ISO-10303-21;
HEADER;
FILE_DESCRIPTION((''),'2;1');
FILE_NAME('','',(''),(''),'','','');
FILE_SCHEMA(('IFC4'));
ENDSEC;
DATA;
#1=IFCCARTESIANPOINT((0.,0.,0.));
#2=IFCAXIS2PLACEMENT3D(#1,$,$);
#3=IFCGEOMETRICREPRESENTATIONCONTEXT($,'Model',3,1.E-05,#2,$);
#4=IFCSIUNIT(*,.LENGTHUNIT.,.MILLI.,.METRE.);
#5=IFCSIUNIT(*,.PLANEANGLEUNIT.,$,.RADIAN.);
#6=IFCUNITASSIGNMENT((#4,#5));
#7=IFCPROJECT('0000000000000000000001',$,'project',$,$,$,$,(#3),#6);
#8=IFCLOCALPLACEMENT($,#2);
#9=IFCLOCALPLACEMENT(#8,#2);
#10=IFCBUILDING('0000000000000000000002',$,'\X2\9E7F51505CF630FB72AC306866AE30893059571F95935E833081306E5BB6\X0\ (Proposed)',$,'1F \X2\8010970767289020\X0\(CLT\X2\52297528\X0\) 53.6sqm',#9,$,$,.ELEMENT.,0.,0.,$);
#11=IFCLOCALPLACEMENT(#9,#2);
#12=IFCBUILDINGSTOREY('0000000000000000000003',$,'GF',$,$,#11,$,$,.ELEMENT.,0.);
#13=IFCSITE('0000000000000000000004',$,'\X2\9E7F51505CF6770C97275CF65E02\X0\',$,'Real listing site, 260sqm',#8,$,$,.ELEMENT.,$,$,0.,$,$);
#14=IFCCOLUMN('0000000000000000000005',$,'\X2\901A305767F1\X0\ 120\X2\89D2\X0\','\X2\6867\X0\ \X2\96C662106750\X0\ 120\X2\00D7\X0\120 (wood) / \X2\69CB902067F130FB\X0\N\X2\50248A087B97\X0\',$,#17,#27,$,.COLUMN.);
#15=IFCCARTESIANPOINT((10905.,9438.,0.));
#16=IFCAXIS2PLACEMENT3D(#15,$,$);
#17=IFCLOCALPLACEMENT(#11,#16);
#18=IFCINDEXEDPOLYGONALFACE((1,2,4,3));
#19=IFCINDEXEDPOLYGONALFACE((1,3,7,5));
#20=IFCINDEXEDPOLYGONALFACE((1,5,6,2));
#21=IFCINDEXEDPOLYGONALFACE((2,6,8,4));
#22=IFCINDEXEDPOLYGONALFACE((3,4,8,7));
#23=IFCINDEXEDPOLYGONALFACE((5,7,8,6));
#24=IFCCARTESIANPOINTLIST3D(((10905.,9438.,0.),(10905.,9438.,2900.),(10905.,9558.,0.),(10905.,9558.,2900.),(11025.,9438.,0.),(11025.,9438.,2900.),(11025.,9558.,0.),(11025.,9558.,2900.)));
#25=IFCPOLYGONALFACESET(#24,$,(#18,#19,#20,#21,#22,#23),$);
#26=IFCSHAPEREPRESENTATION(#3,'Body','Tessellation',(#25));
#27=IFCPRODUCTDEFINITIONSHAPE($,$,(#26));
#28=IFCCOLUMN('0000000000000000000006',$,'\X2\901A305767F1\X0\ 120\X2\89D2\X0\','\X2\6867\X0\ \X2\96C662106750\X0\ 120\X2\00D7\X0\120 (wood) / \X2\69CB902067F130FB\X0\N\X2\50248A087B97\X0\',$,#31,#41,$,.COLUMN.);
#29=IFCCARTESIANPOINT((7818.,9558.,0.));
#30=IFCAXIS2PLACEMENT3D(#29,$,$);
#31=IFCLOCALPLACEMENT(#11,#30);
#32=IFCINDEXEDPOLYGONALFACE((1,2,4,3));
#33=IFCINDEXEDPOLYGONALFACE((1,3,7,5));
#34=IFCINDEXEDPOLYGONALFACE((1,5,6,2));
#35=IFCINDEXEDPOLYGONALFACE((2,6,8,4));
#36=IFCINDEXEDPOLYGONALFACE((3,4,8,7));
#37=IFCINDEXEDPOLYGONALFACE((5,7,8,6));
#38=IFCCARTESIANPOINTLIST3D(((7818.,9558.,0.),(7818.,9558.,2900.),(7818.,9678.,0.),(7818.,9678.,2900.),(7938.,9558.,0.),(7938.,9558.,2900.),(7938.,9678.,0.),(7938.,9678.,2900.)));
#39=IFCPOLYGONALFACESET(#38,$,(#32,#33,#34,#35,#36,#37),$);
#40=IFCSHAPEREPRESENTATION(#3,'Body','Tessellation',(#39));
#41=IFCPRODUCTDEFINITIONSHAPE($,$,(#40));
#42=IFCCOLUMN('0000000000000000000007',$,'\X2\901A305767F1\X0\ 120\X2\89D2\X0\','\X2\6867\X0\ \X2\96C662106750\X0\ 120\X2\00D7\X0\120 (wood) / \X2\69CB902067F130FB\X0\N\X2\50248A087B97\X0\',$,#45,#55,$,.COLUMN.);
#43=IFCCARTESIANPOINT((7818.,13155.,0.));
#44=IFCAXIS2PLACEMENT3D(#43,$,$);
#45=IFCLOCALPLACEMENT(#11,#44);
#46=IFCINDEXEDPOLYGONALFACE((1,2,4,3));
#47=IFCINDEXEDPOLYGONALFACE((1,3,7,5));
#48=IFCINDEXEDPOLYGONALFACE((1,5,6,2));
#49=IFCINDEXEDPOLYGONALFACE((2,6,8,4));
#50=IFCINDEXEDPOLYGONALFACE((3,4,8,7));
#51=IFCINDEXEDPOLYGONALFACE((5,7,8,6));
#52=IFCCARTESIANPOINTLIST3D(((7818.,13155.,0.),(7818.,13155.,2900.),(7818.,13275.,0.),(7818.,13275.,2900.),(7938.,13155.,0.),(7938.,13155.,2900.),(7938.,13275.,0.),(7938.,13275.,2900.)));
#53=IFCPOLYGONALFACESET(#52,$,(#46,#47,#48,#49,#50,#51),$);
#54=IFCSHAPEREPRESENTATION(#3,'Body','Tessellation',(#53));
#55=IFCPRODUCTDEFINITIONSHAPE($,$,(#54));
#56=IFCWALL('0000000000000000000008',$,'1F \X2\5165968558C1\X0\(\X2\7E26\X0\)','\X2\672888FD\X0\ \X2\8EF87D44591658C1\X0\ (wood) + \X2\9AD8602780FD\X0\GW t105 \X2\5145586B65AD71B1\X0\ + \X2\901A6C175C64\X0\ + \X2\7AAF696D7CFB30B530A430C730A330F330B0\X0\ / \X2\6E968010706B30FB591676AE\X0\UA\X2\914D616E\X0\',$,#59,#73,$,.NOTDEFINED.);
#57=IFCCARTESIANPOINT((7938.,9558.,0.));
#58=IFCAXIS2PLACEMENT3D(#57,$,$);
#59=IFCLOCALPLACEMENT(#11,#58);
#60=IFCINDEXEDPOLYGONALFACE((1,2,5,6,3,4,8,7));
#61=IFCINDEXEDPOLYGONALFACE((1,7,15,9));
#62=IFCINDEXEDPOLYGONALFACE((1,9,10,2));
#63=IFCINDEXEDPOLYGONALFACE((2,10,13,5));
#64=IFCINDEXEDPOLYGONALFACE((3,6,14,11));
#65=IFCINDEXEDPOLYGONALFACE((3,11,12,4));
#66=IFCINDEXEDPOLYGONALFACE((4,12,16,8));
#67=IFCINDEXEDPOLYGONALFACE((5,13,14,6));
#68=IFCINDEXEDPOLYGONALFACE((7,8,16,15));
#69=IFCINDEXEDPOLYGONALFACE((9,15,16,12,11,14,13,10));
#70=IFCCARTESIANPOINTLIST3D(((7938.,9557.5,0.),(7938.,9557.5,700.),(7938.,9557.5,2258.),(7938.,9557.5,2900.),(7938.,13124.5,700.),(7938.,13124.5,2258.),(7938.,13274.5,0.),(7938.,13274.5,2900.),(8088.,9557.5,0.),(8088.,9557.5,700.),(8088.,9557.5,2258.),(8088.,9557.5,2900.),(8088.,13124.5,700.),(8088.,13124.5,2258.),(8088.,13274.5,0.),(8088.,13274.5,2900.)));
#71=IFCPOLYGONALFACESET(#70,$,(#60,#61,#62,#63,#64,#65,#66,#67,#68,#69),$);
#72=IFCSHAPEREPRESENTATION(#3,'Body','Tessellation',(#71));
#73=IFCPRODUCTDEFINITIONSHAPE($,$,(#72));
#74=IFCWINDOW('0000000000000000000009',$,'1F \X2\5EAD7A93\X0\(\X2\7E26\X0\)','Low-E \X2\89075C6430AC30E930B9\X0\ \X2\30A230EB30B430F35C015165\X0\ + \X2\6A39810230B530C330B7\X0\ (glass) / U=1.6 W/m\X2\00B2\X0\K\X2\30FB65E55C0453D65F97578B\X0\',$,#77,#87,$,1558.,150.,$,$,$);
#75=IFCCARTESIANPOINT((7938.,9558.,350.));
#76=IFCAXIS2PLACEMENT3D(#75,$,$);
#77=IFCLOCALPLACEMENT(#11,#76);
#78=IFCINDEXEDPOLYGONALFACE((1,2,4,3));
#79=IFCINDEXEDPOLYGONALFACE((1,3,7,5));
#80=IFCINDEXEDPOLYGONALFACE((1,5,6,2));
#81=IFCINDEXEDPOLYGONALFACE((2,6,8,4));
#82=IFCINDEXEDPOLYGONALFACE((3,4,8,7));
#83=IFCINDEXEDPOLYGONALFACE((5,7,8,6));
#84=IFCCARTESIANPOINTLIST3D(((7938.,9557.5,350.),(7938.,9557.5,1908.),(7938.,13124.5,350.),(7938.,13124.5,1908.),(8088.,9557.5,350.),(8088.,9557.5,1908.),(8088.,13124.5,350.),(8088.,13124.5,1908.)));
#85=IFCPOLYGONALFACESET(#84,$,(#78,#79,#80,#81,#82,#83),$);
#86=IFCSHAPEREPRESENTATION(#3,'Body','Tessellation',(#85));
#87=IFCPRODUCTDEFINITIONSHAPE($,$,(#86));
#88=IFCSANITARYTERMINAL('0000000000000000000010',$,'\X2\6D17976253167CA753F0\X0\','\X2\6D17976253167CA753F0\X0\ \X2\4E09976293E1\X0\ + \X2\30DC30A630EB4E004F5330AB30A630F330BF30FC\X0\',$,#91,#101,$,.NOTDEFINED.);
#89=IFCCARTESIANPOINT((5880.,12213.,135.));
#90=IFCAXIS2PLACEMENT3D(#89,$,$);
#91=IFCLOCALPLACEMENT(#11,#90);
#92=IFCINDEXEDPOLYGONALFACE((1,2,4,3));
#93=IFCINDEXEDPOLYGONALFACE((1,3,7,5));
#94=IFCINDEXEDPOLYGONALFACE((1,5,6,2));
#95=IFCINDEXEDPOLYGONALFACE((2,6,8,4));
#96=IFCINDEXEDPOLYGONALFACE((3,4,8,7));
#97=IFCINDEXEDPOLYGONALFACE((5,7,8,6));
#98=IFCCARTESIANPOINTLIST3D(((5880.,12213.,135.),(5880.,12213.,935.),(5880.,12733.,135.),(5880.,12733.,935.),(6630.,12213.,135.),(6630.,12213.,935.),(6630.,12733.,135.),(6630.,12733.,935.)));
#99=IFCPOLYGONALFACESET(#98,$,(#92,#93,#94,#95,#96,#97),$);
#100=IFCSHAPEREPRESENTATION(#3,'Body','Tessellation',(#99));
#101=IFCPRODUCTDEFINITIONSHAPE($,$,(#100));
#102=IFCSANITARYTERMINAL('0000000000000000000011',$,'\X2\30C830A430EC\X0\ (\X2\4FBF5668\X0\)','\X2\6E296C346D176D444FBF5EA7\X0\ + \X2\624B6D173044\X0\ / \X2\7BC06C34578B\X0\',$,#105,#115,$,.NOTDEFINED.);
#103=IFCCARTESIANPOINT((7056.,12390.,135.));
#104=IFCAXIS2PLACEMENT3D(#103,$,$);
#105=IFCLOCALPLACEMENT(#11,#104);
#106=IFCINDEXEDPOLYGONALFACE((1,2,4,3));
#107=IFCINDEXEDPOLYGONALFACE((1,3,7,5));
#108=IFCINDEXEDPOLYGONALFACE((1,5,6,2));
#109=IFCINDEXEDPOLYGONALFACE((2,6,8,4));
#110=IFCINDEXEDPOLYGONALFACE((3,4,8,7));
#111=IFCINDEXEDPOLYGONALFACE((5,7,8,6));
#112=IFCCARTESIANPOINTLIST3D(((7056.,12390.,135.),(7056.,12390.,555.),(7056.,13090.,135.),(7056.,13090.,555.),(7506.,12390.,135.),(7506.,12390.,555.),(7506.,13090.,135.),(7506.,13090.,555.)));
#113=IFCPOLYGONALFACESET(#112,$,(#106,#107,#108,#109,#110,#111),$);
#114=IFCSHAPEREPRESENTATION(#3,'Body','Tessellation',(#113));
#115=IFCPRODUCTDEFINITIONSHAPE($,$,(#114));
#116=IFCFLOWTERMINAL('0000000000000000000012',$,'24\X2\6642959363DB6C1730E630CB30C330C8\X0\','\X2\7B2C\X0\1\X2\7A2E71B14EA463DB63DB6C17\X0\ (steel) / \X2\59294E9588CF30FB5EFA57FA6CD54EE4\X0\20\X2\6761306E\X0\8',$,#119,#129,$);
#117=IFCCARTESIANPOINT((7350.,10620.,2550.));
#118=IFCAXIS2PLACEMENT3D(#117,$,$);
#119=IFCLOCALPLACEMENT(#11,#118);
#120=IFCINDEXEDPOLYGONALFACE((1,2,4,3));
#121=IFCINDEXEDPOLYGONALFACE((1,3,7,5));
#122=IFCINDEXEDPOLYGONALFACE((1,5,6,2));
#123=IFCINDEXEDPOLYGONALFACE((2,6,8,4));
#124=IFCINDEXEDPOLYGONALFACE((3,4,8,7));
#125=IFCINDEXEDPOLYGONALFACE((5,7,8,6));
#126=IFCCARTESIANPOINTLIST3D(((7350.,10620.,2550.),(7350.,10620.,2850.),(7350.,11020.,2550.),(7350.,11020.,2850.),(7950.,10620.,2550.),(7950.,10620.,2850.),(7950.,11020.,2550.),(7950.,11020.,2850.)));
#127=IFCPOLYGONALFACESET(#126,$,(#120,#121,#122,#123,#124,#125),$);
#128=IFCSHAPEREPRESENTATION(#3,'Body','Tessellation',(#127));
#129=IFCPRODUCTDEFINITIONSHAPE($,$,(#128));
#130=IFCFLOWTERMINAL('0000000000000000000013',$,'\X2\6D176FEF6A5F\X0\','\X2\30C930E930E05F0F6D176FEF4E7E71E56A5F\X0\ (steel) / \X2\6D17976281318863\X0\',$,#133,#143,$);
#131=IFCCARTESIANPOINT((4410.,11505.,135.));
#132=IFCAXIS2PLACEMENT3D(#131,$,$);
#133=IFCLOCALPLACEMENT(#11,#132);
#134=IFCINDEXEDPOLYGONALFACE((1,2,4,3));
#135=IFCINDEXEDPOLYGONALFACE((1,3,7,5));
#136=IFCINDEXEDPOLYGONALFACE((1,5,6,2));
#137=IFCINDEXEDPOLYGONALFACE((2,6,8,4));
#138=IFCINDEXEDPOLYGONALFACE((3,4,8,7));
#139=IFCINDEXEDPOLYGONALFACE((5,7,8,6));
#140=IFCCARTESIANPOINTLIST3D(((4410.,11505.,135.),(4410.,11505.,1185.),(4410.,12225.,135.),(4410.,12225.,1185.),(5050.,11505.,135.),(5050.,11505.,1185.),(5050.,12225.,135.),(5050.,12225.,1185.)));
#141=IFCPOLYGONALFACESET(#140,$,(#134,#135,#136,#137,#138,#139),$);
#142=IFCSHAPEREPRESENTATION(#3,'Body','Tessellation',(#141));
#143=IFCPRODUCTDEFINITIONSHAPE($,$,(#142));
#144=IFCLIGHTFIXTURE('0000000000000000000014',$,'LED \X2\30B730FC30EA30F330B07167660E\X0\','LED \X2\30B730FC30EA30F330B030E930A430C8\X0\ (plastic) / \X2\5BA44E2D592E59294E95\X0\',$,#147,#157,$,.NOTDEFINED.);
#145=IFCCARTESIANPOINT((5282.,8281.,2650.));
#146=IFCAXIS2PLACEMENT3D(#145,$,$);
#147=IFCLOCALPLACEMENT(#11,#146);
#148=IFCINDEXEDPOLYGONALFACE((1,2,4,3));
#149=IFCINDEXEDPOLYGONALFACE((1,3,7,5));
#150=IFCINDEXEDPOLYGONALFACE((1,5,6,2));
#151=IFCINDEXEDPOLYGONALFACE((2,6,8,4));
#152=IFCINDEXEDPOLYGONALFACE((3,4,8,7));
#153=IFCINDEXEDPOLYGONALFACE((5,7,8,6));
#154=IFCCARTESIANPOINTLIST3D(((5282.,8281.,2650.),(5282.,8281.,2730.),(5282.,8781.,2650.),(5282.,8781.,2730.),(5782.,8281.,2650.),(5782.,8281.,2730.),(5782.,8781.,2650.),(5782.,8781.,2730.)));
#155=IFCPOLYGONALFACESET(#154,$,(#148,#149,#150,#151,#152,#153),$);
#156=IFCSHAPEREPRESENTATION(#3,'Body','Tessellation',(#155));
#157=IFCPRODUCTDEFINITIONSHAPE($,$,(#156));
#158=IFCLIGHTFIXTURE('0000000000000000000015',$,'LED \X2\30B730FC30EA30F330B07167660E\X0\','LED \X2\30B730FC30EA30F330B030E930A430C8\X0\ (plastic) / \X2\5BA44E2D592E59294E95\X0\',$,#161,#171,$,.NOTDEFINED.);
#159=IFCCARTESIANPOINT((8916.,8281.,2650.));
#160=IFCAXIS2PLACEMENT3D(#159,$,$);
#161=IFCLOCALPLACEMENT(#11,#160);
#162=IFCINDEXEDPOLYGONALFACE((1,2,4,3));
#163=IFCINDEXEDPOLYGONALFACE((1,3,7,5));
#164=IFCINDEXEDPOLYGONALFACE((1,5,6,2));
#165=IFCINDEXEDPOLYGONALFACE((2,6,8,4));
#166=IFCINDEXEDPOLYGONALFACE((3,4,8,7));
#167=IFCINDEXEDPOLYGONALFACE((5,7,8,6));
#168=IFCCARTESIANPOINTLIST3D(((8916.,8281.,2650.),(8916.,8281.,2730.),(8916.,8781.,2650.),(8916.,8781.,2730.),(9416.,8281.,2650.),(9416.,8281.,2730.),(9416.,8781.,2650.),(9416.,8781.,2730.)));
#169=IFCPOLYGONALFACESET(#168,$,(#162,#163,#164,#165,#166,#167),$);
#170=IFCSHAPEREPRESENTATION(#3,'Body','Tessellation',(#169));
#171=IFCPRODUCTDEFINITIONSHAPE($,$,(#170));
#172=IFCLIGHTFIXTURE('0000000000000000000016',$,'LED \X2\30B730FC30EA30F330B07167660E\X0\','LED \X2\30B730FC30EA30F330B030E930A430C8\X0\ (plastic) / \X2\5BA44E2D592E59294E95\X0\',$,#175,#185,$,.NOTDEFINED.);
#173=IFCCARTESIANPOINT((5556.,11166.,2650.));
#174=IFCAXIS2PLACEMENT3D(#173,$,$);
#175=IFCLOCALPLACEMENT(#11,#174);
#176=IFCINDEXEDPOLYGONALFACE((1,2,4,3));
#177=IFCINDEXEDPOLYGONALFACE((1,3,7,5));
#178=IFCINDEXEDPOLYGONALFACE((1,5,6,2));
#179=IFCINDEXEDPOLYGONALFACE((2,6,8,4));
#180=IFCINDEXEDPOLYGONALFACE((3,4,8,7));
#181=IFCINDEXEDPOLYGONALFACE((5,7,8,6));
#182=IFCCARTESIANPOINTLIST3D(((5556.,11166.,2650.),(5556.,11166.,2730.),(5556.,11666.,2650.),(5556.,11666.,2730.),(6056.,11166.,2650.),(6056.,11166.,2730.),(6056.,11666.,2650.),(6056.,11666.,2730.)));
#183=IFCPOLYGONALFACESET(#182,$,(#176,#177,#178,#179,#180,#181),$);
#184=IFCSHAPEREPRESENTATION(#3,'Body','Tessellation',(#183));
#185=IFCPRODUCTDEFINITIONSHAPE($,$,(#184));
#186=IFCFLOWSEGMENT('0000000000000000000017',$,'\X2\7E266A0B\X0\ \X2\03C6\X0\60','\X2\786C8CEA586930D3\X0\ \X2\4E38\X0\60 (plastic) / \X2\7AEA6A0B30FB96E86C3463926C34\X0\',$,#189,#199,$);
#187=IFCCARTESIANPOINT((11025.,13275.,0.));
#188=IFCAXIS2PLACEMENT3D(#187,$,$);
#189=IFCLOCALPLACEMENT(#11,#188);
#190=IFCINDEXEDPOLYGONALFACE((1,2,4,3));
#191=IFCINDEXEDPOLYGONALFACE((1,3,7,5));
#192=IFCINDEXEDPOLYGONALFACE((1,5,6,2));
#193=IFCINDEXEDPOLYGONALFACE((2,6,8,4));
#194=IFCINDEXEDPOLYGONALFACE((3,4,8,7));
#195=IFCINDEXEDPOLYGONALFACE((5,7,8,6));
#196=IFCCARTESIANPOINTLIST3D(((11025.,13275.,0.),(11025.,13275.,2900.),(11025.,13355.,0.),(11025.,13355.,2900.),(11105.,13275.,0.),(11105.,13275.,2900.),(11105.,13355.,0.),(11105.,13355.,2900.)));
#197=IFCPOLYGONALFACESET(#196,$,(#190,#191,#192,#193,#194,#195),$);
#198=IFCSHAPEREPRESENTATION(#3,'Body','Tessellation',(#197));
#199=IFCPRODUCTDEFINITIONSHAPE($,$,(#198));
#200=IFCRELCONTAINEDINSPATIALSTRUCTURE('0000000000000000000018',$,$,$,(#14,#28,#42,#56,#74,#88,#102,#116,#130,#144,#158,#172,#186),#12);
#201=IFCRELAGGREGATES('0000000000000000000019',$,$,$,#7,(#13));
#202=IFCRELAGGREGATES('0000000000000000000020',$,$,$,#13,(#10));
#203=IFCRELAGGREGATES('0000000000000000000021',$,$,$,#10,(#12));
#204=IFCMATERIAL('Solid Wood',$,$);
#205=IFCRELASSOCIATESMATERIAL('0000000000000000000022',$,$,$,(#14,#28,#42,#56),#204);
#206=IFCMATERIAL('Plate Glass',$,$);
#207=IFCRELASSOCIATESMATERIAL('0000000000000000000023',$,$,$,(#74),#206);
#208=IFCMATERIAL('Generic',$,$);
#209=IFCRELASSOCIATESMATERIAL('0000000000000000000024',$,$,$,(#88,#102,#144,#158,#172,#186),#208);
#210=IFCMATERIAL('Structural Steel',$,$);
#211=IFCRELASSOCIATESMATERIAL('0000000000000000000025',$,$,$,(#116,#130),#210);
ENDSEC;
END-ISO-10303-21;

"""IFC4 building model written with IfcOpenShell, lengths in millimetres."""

from ifc_helpers import new_model, si_unit, frame, frame_2d, origin, place, context, project, spatial, rectangle, extrude, material, element, fill, save


model = new_model("IFC4")

# Units and contexts
model_context = context("Model", 3, precision=1e-05, world=origin())
ifc_project = project(units=[si_unit("LENGTHUNIT", "METRE", prefix="MILLI"), si_unit("PLANEANGLEUNIT", "RADIAN")], contexts=[model_context])

# Site, building, storey
site_placement = place(None, origin())
site = spatial("IfcSite", under=ifc_project, at=site_placement, Name="鹿児島県霧島市", ObjectType="Real listing site, 260sqm", CompositionType="ELEMENT", RefElevation=0.0)
building_placement = place(site_placement, origin())
building = spatial("IfcBuilding", under=site, at=building_placement, Name="鹿児島・犬と暮らす土間広めの家 (Proposed)", ObjectType="1F 耐震木造(CLT利用) 53.6sqm", CompositionType="ELEMENT", ElevationOfRefHeight=0.0, ElevationOfTerrain=0.0)
storey_placement = place(building_placement, origin())
storey = spatial("IfcBuildingStorey", under=building, at=storey_placement, Name="GF", CompositionType="ELEMENT", Elevation=0.0)

# Columns
ifc_material_1 = material(Name="Solid Wood")
column_1_placement = place(storey_placement, frame((10905.0, 9438.0, 0.0)))
element("IfcColumn", 1, at=column_1_placement, inside=storey, material=ifc_material_1, Name="通し柱 120角", Description="桧 集成材 120×120 (wood) / 構造柱・N値計算", PredefinedType="COLUMN", context=model_context, shape_type="SweptSolid", body=[
    extrude(rectangle(XDim=120.0, YDim=120.0, at=frame_2d((60.0, 60.0))), frame((10905.0, 9438.0, 0.0)), (0.0, 0.0, 1.0), 2900.0),
])
column_2_placement = place(storey_placement, frame((7818.0, 9558.0, 0.0)))
element("IfcColumn", 2, at=column_2_placement, inside=storey, material=ifc_material_1, Name="通し柱 120角", Description="桧 集成材 120×120 (wood) / 構造柱・N値計算", PredefinedType="COLUMN", context=model_context, shape_type="SweptSolid", body=[
    extrude(rectangle(XDim=120.0, YDim=120.0, at=frame_2d((60.0, 60.0))), frame((7818.0, 9558.0, 0.0)), (0.0, 0.0, 1.0), 2900.0),
])
column_3_placement = place(storey_placement, frame((7818.0, 13155.0, 0.0)))
element("IfcColumn", 3, at=column_3_placement, inside=storey, material=ifc_material_1, Name="通し柱 120角", Description="桧 集成材 120×120 (wood) / 構造柱・N値計算", PredefinedType="COLUMN", context=model_context, shape_type="SweptSolid", body=[
    extrude(rectangle(XDim=120.0, YDim=120.0, at=frame_2d((60.0, 60.0))), frame((7818.0, 13155.0, 0.0)), (0.0, 0.0, 1.0), 2900.0),
])

# Wall, opening, window
wall_1_placement = place(storey_placement, frame((7938.0, 9558.0, 0.0)))
wall_1 = element("IfcWall", 4, at=wall_1_placement, inside=storey, material=ifc_material_1, Name="1F 入隅壁(縦)", Description="木製 軸組外壁 (wood) + 高性能GW t105 充填断熱 + 通気層 + 窯業系サイディング / 準耐火・外皮UA配慮", PredefinedType="NOTDEFINED", context=model_context, shape_type="SweptSolid", body=[
    extrude(rectangle(XDim=150.0, YDim=3717.0, at=frame_2d((75.0, 1858.0))), frame((7938.0, 9558.0, 0.0)), (0.0, 0.0, 1.0), 2900.0),
])
opening_placement = place(storey_placement, frame((7938.0, 9558.0, 350.0)))
opening = element("IfcOpeningElement", 5, at=opening_placement, cuts=wall_1, PredefinedType="NOTDEFINED", context=model_context, shape_type="SweptSolid", body=[
    extrude(rectangle(XDim=150.0, YDim=3567.0, at=frame_2d((75.0, 1783.0))), frame((7938.0, 9558.0, 350.0)), (0.0, 0.0, 1.0), 1558.0),
])
ifc_material_2 = material(Name="Plate Glass")
window_placement = place(storey_placement, frame((7938.0, 9558.0, 350.0)))
window = element("IfcWindow", 6, at=window_placement, inside=storey, material=ifc_material_2, Name="1F 庭窓(縦)", Description="Low-E 複層ガラス アルゴン封入 + 樹脂サッシ (glass) / U=1.6 W/m²K・日射取得型", OverallHeight=1558.0, OverallWidth=150.0, context=model_context, shape_type="SweptSolid", body=[
    extrude(rectangle(XDim=150.0, YDim=3567.0, at=frame_2d((75.0, 1783.0))), frame((7938.0, 9558.0, 350.0)), (0.0, 0.0, 1.0), 1558.0),
])
fill(opening, window)

# Sanitary terminals
ifc_material_3 = material(Name="Generic")
sanitary_terminal_1_placement = place(storey_placement, frame((5880.0, 12213.0, 135.0)))
element("IfcSanitaryTerminal", 7, at=sanitary_terminal_1_placement, inside=storey, material=ifc_material_3, Name="洗面化粧台", Description="洗面化粧台 三面鏡 + ボウル一体カウンター", PredefinedType="NOTDEFINED", context=model_context, shape_type="SweptSolid", body=[
    extrude(rectangle(XDim=750.0, YDim=520.0, at=frame_2d((375.0, 260.0))), frame((5880.0, 12213.0, 135.0)), (0.0, 0.0, 1.0), 800.0),
])
sanitary_terminal_2_placement = place(storey_placement, frame((7056.0, 12390.0, 135.0)))
element("IfcSanitaryTerminal", 8, at=sanitary_terminal_2_placement, inside=storey, material=ifc_material_3, Name="トイレ (便器)", Description="温水洗浄便座 + 手洗い / 節水型", PredefinedType="NOTDEFINED", context=model_context, shape_type="SweptSolid", body=[
    extrude(rectangle(XDim=450.0, YDim=700.0, at=frame_2d((225.0, 350.0))), frame((7056.0, 12390.0, 135.0)), (0.0, 0.0, 1.0), 420.0),
])

# Flow terminals
ifc_material_4 = material(Name="Structural Steel")
flow_terminal_1_placement = place(storey_placement, frame((7350.0, 10620.0, 2550.0)))
element("IfcFlowTerminal", 9, at=flow_terminal_1_placement, inside=storey, material=ifc_material_4, Name="24時間換気ユニット", Description="第1種熱交換換気 (steel) / 天井裏・建基法令20条の8", context=model_context, shape_type="SweptSolid", body=[
    extrude(rectangle(XDim=600.0, YDim=400.0, at=frame_2d((300.0, 200.0))), frame((7350.0, 10620.0, 2550.0)), (0.0, 0.0, 1.0), 300.0),
])
flow_terminal_2_placement = place(storey_placement, frame((4410.0, 11505.0, 135.0)))
element("IfcFlowTerminal", 10, at=flow_terminal_2_placement, inside=storey, material=ifc_material_4, Name="洗濯機", Description="ドラム式洗濯乾燥機 (steel) / 洗面脱衣", context=model_context, shape_type="SweptSolid", body=[
    extrude(rectangle(XDim=640.0, YDim=720.0, at=frame_2d((320.0, 360.0))), frame((4410.0, 11505.0, 135.0)), (0.0, 0.0, 1.0), 1050.0),
])

# Light fixtures
light_fixture_1_placement = place(storey_placement, frame((5282.0, 8281.0, 2650.0)))
element("IfcLightFixture", 11, at=light_fixture_1_placement, inside=storey, material=ifc_material_3, Name="LED シーリング照明", Description="LED シーリングライト (plastic) / 室中央天井", PredefinedType="NOTDEFINED", context=model_context, shape_type="SweptSolid", body=[
    extrude(rectangle(XDim=500.0, YDim=500.0, at=frame_2d((250.0, 250.0))), frame((5282.0, 8281.0, 2650.0)), (0.0, 0.0, 1.0), 80.0),
])
light_fixture_2_placement = place(storey_placement, frame((8916.0, 8281.0, 2650.0)))
element("IfcLightFixture", 12, at=light_fixture_2_placement, inside=storey, material=ifc_material_3, Name="LED シーリング照明", Description="LED シーリングライト (plastic) / 室中央天井", PredefinedType="NOTDEFINED", context=model_context, shape_type="SweptSolid", body=[
    extrude(rectangle(XDim=500.0, YDim=500.0, at=frame_2d((250.0, 250.0))), frame((8916.0, 8281.0, 2650.0)), (0.0, 0.0, 1.0), 80.0),
])
light_fixture_3_placement = place(storey_placement, frame((5556.0, 11166.0, 2650.0)))
element("IfcLightFixture", 13, at=light_fixture_3_placement, inside=storey, material=ifc_material_3, Name="LED シーリング照明", Description="LED シーリングライト (plastic) / 室中央天井", PredefinedType="NOTDEFINED", context=model_context, shape_type="SweptSolid", body=[
    extrude(rectangle(XDim=500.0, YDim=500.0, at=frame_2d((250.0, 250.0))), frame((5556.0, 11166.0, 2650.0)), (0.0, 0.0, 1.0), 80.0),
])

# Flow segment
flow_segment_placement = place(storey_placement, frame((11025.0, 13275.0, 0.0)))
element("IfcFlowSegment", 14, at=flow_segment_placement, inside=storey, material=ifc_material_3, Name="縦樋 φ60", Description="硬質塩ビ 丸60 (plastic) / 竪樋・雨水排水", context=model_context, shape_type="SweptSolid", body=[
    extrude(rectangle(XDim=80.0, YDim=80.0, at=frame_2d((40.0, 40.0))), frame((11025.0, 13275.0, 0.0)), (0.0, 0.0, 1.0), 2900.0),
])

save(model, "model.ifc")
